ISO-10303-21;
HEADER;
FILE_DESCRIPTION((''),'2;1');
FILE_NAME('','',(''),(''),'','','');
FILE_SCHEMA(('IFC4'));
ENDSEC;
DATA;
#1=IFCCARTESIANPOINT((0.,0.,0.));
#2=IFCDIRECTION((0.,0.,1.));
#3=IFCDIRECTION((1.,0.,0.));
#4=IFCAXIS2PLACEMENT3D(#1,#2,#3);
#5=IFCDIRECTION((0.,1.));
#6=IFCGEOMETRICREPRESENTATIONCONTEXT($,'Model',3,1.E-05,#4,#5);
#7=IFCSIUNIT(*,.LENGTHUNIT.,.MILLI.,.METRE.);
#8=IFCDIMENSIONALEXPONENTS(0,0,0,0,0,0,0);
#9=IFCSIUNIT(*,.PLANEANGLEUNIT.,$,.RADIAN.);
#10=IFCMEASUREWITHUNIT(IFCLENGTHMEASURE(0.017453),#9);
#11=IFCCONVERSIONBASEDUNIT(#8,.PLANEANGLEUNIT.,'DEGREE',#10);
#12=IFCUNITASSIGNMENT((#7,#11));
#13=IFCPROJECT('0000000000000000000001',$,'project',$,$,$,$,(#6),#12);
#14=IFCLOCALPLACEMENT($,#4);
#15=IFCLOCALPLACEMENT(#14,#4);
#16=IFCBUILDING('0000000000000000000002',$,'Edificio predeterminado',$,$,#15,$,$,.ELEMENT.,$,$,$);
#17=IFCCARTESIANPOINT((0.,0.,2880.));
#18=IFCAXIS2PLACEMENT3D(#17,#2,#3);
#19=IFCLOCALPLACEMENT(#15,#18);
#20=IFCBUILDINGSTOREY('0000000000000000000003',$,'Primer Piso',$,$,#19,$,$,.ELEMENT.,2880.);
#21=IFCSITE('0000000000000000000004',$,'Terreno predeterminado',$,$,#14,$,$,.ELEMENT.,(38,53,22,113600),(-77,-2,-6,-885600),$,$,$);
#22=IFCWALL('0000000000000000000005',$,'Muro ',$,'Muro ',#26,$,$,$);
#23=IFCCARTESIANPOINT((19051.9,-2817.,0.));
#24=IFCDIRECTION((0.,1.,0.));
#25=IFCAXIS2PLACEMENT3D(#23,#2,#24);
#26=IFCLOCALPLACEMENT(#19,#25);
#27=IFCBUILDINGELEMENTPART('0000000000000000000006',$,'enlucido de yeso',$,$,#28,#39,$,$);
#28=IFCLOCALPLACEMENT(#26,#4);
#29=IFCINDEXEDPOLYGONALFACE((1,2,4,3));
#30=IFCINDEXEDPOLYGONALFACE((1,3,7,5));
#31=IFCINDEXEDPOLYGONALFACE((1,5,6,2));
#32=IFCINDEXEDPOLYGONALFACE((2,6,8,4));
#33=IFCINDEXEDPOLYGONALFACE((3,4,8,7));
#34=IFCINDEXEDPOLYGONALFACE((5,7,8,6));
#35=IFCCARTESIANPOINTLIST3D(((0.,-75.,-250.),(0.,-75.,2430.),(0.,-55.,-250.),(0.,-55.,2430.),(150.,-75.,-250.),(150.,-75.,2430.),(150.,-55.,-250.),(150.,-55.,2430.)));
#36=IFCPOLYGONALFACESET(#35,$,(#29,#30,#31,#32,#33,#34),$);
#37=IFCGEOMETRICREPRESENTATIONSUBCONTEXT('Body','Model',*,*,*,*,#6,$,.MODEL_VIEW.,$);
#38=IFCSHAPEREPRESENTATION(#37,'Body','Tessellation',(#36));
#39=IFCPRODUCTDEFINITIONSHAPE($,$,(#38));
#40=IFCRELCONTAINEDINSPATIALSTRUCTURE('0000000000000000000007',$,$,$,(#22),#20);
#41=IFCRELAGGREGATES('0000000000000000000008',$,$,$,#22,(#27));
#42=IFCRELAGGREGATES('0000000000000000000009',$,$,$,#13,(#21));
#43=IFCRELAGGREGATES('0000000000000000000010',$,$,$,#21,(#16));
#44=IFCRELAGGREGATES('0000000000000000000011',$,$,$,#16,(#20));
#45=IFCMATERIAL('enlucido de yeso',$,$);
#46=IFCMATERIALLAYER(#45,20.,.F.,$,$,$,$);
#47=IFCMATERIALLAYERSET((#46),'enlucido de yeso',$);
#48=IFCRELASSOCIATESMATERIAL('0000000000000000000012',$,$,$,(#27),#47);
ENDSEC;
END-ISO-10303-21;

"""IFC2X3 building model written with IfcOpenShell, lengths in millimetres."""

from ifc_helpers import new_model, entity, si_unit, converted_unit, direction, frame, origin_with_axes, place, context, subcontext, project, spatial, polyline, outline, extrude, clip, bounded_halfspace, material, layer, layer_set, layer_usage, element, aggregate, save


model = new_model("IFC2X3")

# Units and contexts
model_context = context("Model", 3, precision=1e-05, world=origin_with_axes(), true_north=direction((0.0, 1.0)))
body_context = subcontext(model_context, "Body", "Model", "MODEL_VIEW")
ifc_project = project(units=[si_unit("LENGTHUNIT", "METRE", prefix="MILLI"), converted_unit("PLANEANGLEUNIT", "DEGREE", entity("IfcLengthMeasure", 0.017453), si_unit("PLANEANGLEUNIT", "RADIAN"), dimensions=[0, 0, 0, 0, 0, 0, 0])], contexts=[model_context])

# Site, building, storey
site_placement = place(None, origin_with_axes())
site = spatial("IfcSite", under=ifc_project, at=site_placement, Name="Terreno predeterminado", CompositionType="ELEMENT", RefLatitude=(38, 53, 22, 113600), RefLongitude=(-77, -2, -6, -885600))
building_placement = place(site_placement, origin_with_axes())
building = spatial("IfcBuilding", under=site, at=building_placement, Name="Edificio predeterminado", CompositionType="ELEMENT")
storey_placement = place(building_placement, frame((0.0, 0.0, 2880.0), z_axis=(0.0, 0.0, 1.0), x_axis=(1.0, 0.0, 0.0)))
storey = spatial("IfcBuildingStorey", under=building, at=storey_placement, Name="Primer Piso", CompositionType="ELEMENT", Elevation=2880.0)

# Wall, building element part
wall_1_placement = place(storey_placement, frame((19051.9, -2817.0, 0.0), z_axis=(0.0, 0.0, 1.0), x_axis=(0.0, 1.0, 0.0)))
wall_1 = element("IfcWall", 1, at=wall_1_placement, inside=storey, Name="Muro ", ObjectType="Muro ")
ifc_material_1 = material(Name="enlucido de yeso")
ifc_layer_1 = layer(ifc_material_1, 20.0, ventilated=False)
ifc_layer_set_1 = layer_set([ifc_layer_1], Name="enlucido de yeso")
ifc_layer_usage_1 = layer_usage(ifc_layer_set_1, "AXIS2", "NEGATIVE", 55.0)
building_element_part_1_placement = place(wall_1_placement, origin_with_axes())
building_element_part_1 = element("IfcBuildingElementPart", 2, at=building_element_part_1_placement, material=ifc_layer_usage_1, Name="enlucido de yeso", context=body_context, shape_type="Clipping", body=[
    clip(clip(extrude(outline(polyline([(150.0, -55.0), (150.0, -75.0), (0.0, -75.0), (0.0, -55.0), (150.0, -55.0)])), frame((0.0, 0.0, -250.0), z_axis=(0.0, 0.0, 1.0), x_axis=(1.0, 0.0, 0.0)), (0.0, 0.0, 1.0), 2680.0), bounded_halfspace(frame((0.0, 0.0, -250.0), z_axis=(0.0, 0.0, 1.0), x_axis=(1.0, 0.0, 0.0)), True, origin_with_axes(), polyline([(-150.0, -150.0), (375.0, -150.0), (375.0, 150.0), (-150.0, 150.0), (-150.0, -150.0)]))), bounded_halfspace(frame((0.0, 0.0, 2430.0), z_axis=(0.0, 0.0, 1.0), x_axis=(1.0, 0.0, 0.0)), False, origin_with_axes(), polyline([(-150.0, -150.0), (375.0, -150.0), (375.0, 150.0), (-150.0, 150.0), (-150.0, -150.0)]))),
])
aggregate(wall_1, [building_element_part_1])

save(model, "model.ifc")
